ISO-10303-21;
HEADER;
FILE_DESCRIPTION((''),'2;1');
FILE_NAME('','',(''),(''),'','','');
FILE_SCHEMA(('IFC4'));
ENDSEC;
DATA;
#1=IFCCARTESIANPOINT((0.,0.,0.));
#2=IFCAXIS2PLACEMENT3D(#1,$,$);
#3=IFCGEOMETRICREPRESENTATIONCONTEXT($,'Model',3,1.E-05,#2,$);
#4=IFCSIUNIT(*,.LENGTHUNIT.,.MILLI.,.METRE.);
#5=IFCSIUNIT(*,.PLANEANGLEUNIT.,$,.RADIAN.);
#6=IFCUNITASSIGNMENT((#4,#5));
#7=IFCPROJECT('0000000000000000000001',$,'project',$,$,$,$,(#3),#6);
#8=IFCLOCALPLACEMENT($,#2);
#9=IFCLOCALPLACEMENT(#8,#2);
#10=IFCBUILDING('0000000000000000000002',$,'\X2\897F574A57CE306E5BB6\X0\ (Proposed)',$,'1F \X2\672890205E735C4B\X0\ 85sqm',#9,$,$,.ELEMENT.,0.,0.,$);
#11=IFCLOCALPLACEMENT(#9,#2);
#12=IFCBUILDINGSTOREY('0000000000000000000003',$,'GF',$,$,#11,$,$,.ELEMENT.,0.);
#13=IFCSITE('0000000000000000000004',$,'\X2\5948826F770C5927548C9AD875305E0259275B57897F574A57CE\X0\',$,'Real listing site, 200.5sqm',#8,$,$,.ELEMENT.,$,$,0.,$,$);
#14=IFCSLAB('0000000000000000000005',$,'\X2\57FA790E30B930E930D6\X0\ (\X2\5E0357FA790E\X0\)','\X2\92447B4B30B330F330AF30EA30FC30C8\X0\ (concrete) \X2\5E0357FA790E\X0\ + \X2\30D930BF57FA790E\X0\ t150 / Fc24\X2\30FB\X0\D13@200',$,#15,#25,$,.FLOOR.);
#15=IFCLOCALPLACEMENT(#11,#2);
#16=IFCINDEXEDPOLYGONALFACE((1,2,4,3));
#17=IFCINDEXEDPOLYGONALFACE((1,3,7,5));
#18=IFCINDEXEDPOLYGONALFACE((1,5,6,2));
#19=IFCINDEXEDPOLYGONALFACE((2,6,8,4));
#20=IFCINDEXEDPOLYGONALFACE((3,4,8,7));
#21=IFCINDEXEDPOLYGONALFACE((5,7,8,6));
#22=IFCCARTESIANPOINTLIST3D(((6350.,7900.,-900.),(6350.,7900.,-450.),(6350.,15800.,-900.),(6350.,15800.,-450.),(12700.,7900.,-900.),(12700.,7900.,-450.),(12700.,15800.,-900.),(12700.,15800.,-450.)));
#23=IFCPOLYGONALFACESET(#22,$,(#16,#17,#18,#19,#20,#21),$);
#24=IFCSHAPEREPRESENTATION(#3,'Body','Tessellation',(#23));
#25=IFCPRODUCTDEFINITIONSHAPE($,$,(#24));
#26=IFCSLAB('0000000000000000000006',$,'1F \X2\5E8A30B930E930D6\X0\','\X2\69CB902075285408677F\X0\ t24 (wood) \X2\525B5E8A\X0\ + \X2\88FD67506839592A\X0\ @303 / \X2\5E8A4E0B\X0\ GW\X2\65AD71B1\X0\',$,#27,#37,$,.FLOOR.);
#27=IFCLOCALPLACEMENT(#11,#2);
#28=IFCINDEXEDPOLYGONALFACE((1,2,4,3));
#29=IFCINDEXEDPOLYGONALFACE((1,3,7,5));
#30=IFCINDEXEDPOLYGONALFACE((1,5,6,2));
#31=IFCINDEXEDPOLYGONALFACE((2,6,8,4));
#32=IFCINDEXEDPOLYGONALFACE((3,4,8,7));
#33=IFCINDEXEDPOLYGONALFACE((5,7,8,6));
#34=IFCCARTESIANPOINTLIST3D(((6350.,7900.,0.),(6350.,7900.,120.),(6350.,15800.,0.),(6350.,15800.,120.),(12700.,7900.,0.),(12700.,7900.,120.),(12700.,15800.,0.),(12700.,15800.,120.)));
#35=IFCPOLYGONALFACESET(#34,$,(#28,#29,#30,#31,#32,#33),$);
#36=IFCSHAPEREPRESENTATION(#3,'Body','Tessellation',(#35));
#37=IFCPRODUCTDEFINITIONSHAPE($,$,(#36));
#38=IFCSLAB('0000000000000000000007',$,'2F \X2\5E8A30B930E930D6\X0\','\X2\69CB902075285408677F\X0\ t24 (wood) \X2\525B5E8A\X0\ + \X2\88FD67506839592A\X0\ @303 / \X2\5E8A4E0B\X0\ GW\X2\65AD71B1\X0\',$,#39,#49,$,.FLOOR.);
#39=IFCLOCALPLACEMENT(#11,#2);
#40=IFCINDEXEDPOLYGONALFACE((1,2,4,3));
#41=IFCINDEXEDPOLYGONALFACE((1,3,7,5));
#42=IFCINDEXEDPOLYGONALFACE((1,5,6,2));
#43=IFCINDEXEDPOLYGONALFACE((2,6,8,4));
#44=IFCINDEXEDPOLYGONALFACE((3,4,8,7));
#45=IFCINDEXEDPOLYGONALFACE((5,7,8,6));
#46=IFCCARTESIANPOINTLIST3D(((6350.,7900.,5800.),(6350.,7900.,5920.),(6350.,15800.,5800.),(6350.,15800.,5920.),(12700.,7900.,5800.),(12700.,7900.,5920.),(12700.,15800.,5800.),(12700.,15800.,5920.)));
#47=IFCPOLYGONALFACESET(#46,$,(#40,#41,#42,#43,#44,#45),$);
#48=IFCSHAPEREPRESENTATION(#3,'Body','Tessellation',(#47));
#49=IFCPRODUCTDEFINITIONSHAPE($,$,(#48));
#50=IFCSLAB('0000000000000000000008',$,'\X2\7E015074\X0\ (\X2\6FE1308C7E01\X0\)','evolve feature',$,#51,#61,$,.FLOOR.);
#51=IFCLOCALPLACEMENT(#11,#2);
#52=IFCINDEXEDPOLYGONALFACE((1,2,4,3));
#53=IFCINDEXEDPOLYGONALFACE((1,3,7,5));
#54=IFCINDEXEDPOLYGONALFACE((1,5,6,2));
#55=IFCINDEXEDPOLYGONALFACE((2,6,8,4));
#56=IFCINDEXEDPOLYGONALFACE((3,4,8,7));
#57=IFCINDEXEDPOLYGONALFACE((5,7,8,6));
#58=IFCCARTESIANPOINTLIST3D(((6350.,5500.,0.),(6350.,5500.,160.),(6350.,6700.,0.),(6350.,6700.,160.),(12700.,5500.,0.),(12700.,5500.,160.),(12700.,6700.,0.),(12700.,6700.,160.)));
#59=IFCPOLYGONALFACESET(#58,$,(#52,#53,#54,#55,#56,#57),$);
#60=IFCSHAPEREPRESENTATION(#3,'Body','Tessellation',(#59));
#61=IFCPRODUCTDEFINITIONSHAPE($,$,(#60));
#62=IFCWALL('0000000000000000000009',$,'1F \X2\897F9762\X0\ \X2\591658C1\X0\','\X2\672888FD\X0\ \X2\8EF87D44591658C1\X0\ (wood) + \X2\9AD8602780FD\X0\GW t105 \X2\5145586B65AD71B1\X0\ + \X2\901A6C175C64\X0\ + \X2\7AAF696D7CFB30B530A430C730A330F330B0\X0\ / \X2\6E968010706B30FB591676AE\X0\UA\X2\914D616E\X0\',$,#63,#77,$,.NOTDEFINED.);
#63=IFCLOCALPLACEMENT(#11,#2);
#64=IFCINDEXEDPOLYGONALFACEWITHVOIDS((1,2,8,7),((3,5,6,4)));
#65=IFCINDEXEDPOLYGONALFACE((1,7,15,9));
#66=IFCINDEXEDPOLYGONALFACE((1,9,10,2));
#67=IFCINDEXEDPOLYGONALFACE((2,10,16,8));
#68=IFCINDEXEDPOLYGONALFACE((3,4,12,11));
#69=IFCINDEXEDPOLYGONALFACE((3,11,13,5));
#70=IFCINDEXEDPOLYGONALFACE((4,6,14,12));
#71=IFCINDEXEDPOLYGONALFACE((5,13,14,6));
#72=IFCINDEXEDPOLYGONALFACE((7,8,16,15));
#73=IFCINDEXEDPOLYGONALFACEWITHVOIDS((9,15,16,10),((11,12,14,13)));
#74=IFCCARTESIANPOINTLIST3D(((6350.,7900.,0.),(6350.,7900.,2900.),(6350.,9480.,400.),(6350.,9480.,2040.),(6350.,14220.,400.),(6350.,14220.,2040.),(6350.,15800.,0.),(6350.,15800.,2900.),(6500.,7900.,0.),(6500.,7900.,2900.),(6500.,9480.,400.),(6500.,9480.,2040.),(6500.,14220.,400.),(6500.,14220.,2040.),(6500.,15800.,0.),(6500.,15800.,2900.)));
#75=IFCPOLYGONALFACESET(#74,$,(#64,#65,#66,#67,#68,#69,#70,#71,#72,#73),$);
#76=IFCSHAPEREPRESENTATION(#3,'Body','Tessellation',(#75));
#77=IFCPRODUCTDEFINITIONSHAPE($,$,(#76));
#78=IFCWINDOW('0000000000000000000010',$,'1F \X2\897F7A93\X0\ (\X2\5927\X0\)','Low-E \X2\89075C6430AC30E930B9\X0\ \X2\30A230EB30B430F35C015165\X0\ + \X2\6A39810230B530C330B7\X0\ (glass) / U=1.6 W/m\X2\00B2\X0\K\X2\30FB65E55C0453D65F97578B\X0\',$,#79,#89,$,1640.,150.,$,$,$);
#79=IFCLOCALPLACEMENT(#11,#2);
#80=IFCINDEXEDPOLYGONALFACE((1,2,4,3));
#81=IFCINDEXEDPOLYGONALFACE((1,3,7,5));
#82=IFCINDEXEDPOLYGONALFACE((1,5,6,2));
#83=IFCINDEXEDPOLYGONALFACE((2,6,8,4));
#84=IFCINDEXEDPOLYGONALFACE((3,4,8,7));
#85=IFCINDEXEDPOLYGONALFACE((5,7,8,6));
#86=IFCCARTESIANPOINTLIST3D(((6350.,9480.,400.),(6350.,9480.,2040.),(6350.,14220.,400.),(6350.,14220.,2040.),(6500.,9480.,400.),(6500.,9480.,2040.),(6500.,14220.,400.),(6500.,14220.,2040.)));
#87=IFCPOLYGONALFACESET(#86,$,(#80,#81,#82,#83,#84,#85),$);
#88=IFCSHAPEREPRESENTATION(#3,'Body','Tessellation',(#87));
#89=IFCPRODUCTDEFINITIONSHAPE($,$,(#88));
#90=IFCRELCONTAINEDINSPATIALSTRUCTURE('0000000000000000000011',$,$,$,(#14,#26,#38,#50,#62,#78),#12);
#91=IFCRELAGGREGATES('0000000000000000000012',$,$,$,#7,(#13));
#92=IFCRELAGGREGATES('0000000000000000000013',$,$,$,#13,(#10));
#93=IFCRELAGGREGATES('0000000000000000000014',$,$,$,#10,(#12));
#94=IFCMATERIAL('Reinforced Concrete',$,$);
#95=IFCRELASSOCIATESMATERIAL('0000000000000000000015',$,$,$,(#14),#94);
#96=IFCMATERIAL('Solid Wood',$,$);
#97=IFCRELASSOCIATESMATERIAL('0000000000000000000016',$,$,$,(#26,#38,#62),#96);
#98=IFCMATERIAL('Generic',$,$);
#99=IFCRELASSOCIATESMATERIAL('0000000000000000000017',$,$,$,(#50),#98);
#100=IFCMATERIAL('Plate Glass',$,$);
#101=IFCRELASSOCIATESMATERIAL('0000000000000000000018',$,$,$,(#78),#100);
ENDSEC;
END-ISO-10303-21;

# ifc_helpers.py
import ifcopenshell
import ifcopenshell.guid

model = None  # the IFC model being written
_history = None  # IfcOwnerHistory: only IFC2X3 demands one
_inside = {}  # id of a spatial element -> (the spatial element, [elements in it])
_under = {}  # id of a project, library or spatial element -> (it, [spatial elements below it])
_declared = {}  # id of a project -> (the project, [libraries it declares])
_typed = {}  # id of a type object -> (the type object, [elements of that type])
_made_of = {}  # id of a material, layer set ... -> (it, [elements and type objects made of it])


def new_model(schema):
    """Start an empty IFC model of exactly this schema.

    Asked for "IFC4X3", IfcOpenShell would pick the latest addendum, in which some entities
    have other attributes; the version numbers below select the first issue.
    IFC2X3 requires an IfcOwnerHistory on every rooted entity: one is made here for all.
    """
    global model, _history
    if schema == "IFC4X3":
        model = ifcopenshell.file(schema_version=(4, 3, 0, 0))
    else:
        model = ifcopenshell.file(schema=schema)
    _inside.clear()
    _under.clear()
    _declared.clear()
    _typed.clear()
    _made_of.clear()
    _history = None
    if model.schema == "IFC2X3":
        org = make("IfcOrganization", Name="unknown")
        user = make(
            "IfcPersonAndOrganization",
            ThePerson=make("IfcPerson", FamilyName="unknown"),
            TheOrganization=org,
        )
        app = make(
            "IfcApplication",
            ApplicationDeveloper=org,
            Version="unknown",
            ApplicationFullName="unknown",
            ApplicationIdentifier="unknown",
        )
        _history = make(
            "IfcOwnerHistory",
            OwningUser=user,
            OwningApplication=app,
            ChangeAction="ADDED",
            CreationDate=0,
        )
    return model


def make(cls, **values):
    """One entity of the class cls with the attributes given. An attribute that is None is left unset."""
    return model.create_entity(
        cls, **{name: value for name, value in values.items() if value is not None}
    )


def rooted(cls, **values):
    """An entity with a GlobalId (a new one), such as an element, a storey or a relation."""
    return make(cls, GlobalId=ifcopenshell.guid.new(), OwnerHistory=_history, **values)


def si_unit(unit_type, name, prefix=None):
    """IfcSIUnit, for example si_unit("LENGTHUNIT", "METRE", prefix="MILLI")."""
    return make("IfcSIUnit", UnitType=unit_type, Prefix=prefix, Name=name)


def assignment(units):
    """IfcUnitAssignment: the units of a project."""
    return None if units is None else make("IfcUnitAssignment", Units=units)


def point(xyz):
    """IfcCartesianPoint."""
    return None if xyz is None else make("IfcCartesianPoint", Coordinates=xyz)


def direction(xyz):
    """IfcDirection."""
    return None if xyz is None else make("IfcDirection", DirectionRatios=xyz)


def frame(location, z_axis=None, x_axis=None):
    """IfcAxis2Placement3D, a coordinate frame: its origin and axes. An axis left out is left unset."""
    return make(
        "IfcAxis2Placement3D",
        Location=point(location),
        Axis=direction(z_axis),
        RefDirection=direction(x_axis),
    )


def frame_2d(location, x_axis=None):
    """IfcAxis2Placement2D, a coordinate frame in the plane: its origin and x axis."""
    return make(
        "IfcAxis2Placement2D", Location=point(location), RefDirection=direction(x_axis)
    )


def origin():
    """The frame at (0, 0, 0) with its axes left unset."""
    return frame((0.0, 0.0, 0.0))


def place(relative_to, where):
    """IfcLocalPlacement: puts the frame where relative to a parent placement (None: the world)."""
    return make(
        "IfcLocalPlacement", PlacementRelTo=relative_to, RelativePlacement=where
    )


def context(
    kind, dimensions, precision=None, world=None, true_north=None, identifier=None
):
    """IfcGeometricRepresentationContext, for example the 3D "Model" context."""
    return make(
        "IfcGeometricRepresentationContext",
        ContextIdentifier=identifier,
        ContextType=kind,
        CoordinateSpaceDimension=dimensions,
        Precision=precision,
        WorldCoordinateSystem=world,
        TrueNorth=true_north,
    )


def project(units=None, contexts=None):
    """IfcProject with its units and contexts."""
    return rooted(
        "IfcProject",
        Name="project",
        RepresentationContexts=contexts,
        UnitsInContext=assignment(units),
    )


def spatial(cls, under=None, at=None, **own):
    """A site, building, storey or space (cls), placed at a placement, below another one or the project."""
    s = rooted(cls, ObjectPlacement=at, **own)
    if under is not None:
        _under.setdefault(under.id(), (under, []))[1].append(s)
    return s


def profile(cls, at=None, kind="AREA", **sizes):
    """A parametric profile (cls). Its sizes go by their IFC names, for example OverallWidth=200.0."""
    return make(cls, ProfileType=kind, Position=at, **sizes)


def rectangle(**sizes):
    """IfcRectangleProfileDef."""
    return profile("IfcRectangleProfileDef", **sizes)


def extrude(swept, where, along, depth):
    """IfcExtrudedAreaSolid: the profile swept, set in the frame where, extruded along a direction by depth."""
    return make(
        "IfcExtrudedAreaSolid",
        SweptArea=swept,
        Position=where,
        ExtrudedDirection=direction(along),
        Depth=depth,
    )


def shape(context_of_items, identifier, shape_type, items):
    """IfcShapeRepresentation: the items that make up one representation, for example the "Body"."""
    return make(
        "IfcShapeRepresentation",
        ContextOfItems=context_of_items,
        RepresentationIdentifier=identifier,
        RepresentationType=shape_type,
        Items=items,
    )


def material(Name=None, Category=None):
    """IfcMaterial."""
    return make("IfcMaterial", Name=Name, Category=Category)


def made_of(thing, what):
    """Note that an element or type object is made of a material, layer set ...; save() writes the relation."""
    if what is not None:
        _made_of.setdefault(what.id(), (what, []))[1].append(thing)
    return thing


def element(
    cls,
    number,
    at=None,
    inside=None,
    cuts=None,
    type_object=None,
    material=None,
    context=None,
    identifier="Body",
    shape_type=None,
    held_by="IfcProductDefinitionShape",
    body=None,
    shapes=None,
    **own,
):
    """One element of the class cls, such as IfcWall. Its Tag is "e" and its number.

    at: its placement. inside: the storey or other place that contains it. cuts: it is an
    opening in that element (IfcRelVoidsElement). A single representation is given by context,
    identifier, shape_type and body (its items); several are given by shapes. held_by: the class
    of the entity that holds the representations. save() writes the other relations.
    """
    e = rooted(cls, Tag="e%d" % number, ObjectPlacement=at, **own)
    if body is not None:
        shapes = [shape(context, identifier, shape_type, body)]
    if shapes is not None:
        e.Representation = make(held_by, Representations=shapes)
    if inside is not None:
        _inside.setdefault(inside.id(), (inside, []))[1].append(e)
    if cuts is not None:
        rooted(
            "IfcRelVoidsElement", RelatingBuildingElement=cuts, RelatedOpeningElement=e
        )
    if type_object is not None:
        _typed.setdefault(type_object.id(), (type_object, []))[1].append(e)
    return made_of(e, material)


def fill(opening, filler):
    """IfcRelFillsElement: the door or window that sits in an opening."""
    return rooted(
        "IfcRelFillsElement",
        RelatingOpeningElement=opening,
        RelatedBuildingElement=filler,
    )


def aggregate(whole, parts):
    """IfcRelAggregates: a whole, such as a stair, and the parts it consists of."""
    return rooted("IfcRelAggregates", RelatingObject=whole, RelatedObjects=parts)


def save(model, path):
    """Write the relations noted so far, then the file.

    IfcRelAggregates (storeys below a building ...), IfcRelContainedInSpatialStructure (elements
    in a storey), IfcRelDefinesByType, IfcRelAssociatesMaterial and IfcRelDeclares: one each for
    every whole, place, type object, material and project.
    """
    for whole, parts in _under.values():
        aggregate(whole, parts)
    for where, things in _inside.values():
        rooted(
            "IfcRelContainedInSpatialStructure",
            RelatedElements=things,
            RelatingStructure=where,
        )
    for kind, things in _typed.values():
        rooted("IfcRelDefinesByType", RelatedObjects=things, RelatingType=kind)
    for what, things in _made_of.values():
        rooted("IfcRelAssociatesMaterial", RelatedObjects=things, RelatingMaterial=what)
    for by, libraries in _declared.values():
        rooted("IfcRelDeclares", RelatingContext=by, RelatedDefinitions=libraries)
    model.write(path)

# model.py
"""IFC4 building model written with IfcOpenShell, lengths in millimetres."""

from ifc_helpers import new_model, si_unit, frame, frame_2d, origin, place, context, project, spatial, rectangle, extrude, material, element, fill, save


model = new_model("IFC4")

# Units and contexts
model_context = context("Model", 3, precision=1e-05, world=origin())
ifc_project = project(units=[si_unit("LENGTHUNIT", "METRE", prefix="MILLI"), si_unit("PLANEANGLEUNIT", "RADIAN")], contexts=[model_context])

# Site, building, storey
site_placement = place(None, origin())
site = spatial("IfcSite", under=ifc_project, at=site_placement, Name="奈良県大和高田市大字西坊城", ObjectType="Real listing site, 200.5sqm", CompositionType="ELEMENT", RefElevation=0.0)
building_placement = place(site_placement, origin())
building = spatial("IfcBuilding", under=site, at=building_placement, Name="西坊城の家 (Proposed)", ObjectType="1F 木造平屋 85sqm", CompositionType="ELEMENT", ElevationOfRefHeight=0.0, ElevationOfTerrain=0.0)
storey_placement = place(building_placement, origin())
storey = spatial("IfcBuildingStorey", under=building, at=storey_placement, Name="GF", CompositionType="ELEMENT", Elevation=0.0)

# Slabs
ifc_material_1 = material(Name="Reinforced Concrete")
slab_1_placement = place(storey_placement, frame((3175.0, 3950.0, -450.0)))
element("IfcSlab", 1, at=slab_1_placement, inside=storey, material=ifc_material_1, Name="基礎スラブ (布基礎)", Description="鉄筋コンクリート (concrete) 布基礎 + ベタ基礎 t150 / Fc24・D13@200", PredefinedType="FLOOR", context=model_context, shape_type="SweptSolid", body=[
    extrude(rectangle(XDim=6350.0, YDim=7900.0, at=frame_2d((3175.0, 3950.0))), frame((3175.0, 3950.0, -450.0)), (0.0, 0.0, 1.0), 450.0),
])
ifc_material_2 = material(Name="Solid Wood")
slab_2_placement = place(storey_placement, frame((3175.0, 3950.0, 0.0)))
element("IfcSlab", 2, at=slab_2_placement, inside=storey, material=ifc_material_2, Name="1F 床スラブ", Description="構造用合板 t24 (wood) 剛床 + 製材根太 @303 / 床下 GW断熱", PredefinedType="FLOOR", context=model_context, shape_type="SweptSolid", body=[
    extrude(rectangle(XDim=6350.0, YDim=7900.0, at=frame_2d((3175.0, 3950.0))), frame((3175.0, 3950.0, 0.0)), (0.0, 0.0, 1.0), 120.0),
])
slab_3_placement = place(storey_placement, frame((3175.0, 3950.0, 2900.0)))
element("IfcSlab", 3, at=slab_3_placement, inside=storey, material=ifc_material_2, Name="2F 床スラブ", Description="構造用合板 t24 (wood) 剛床 + 製材根太 @303 / 床下 GW断熱", PredefinedType="FLOOR", context=model_context, shape_type="SweptSolid", body=[
    extrude(rectangle(XDim=6350.0, YDim=7900.0, at=frame_2d((3175.0, 3950.0))), frame((3175.0, 3950.0, 2900.0)), (0.0, 0.0, 1.0), 120.0),
])
ifc_material_3 = material(Name="Generic")
slab_4_placement = place(storey_placement, frame((3175.0, 2750.0, 0.0)))
element("IfcSlab", 4, at=slab_4_placement, inside=storey, material=ifc_material_3, Name="縁側 (濡れ縁)", Description="evolve feature", PredefinedType="FLOOR", context=model_context, shape_type="SweptSolid", body=[
    extrude(rectangle(XDim=6350.0, YDim=1200.0, at=frame_2d((3175.0, 600.0))), frame((3175.0, 2750.0, 0.0)), (0.0, 0.0, 1.0), 160.0),
])

# Shared definitions
ifc_material_4 = material(Name="Plate Glass")

# Wall, opening, window
wall_1_placement = place(storey_placement, frame((3175.0, 3950.0, 0.0)))
wall_1 = element("IfcWall", 5, at=wall_1_placement, inside=storey, material=ifc_material_2, Name="1F 西面 外壁", Description="木製 軸組外壁 (wood) + 高性能GW t105 充填断熱 + 通気層 + 窯業系サイディング / 準耐火・外皮UA配慮", PredefinedType="NOTDEFINED", context=model_context, shape_type="SweptSolid", body=[
    extrude(rectangle(XDim=150.0, YDim=7900.0, at=frame_2d((75.0, 3950.0))), frame((3175.0, 3950.0, 0.0)), (0.0, 0.0, 1.0), 2900.0),
])
opening_1_placement = place(storey_placement, frame((3175.0, 4740.0, 200.0)))
opening_1 = element("IfcOpeningElement", 6, at=opening_1_placement, cuts=wall_1, PredefinedType="NOTDEFINED", context=model_context, shape_type="SweptSolid", body=[
    extrude(rectangle(XDim=150.0, YDim=4740.0, at=frame_2d((75.0, 2370.0))), frame((3175.0, 4740.0, 200.0)), (0.0, 0.0, 1.0), 1640.0),
])
window_1_placement = place(storey_placement, frame((3175.0, 4740.0, 200.0)))
window_1 = element("IfcWindow", 7, at=window_1_placement, inside=storey, material=ifc_material_4, Name="1F 西窓 (大)", Description="Low-E 複層ガラス アルゴン封入 + 樹脂サッシ (glass) / U=1.6 W/m²K・日射取得型", OverallHeight=1640.0, OverallWidth=150.0, context=model_context, shape_type="SweptSolid", body=[
    extrude(rectangle(XDim=150.0, YDim=4740.0, at=frame_2d((75.0, 2370.0))), frame((3175.0, 4740.0, 200.0)), (0.0, 0.0, 1.0), 1640.0),
])
fill(opening_1, window_1)

save(model, "model.ifc")
